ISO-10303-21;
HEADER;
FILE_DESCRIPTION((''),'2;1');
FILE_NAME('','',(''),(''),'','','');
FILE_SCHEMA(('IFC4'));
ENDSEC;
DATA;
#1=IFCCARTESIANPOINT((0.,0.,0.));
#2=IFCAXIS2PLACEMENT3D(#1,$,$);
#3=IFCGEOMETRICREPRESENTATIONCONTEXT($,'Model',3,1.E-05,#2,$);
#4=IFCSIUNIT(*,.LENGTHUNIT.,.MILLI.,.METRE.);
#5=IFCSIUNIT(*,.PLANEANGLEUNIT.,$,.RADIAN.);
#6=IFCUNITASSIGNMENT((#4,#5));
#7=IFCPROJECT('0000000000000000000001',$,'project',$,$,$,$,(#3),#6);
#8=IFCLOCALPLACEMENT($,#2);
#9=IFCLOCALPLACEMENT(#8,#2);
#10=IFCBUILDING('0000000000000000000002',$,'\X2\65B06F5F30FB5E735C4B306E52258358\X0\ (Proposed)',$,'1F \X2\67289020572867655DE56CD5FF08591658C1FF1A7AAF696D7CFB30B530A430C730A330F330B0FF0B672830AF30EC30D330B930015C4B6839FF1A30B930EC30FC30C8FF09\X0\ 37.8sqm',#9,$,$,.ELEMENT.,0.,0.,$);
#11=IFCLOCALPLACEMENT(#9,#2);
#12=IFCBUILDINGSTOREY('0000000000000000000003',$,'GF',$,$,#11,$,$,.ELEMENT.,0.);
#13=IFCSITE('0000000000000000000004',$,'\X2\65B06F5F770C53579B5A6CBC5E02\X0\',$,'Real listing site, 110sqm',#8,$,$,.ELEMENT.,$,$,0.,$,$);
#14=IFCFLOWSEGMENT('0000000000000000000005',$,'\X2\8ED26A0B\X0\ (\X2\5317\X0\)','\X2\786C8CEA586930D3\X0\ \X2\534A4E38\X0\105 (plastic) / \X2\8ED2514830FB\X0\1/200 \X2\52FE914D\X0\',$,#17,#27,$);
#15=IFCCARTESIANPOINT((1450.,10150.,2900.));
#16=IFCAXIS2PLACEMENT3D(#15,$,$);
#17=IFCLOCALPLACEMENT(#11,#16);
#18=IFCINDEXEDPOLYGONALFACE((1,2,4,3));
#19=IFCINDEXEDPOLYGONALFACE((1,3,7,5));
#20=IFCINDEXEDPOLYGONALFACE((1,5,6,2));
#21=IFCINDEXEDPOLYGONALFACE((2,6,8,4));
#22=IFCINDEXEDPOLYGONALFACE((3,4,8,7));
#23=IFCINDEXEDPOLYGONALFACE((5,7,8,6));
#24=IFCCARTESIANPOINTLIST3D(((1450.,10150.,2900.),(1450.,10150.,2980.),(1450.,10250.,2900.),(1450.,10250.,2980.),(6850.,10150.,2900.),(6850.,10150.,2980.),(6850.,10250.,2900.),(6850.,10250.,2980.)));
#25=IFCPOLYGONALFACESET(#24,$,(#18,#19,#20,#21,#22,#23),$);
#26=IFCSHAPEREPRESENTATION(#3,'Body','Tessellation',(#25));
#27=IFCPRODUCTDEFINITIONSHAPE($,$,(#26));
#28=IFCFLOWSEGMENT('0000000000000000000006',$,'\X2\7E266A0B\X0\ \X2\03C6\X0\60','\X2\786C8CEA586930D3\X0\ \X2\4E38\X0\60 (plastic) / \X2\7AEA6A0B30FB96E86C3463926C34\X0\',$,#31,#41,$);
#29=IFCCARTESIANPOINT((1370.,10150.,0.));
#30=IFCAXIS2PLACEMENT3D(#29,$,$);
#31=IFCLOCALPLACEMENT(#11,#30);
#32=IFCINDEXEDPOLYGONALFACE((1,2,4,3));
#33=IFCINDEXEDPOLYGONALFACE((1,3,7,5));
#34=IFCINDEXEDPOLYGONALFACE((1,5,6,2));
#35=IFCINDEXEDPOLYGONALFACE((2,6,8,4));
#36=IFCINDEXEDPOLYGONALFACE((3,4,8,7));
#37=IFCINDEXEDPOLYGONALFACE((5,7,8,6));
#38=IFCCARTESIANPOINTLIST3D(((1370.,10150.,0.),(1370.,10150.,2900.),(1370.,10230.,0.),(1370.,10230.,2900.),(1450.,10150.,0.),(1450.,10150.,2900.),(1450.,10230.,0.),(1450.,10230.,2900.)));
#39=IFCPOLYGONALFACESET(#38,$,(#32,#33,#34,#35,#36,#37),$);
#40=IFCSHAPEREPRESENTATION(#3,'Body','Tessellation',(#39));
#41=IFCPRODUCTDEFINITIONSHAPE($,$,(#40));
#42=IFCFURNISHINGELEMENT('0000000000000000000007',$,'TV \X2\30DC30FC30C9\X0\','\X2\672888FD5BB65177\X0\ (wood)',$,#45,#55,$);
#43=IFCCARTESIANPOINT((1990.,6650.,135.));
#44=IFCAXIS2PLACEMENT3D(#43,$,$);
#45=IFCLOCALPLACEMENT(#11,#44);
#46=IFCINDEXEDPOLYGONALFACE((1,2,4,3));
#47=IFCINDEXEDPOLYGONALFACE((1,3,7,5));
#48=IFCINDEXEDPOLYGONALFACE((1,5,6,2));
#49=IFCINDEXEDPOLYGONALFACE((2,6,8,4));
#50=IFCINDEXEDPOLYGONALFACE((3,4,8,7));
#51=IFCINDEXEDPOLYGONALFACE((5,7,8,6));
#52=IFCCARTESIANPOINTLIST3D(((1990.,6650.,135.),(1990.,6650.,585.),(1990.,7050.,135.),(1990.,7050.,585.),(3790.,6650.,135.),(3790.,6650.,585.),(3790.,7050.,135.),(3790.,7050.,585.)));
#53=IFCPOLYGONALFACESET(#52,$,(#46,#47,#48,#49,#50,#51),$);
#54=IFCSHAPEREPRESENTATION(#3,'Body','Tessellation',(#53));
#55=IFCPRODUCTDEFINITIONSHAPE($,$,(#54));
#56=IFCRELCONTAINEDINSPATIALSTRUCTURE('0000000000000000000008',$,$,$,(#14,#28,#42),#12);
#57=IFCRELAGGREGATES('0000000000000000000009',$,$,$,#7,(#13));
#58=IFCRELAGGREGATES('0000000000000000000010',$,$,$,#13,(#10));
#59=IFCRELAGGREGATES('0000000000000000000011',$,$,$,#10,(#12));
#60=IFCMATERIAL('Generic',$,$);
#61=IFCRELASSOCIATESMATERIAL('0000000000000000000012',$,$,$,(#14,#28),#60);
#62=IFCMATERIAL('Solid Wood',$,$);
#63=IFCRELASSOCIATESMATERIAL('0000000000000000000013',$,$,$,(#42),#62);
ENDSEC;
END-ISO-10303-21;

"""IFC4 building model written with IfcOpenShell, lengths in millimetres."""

from ifc_helpers import new_model, si_unit, frame, frame_2d, origin, place, context, project, spatial, rectangle, extrude, material, element, save


model = new_model("IFC4")

# Units and contexts
model_context = context("Model", 3, precision=1e-05, world=origin())
ifc_project = project(units=[si_unit("LENGTHUNIT", "METRE", prefix="MILLI"), si_unit("PLANEANGLEUNIT", "RADIAN")], contexts=[model_context])

# Site, building, storey
site_placement = place(None, origin())
site = spatial("IfcSite", under=ifc_project, at=site_placement, Name="新潟県南魚沼市", ObjectType="Real listing site, 110sqm", CompositionType="ELEMENT", RefElevation=0.0)
building_placement = place(site_placement, origin())
building = spatial("IfcBuilding", under=site, at=building_placement, Name="新潟・平屋の別荘 (Proposed)", ObjectType="1F 木造在来工法（外壁：窯業系サイディング＋木クレビス、屋根：スレート） 37.8sqm", CompositionType="ELEMENT", ElevationOfRefHeight=0.0, ElevationOfTerrain=0.0)
storey_placement = place(building_placement, origin())
storey = spatial("IfcBuildingStorey", under=building, at=storey_placement, Name="GF", CompositionType="ELEMENT", Elevation=0.0)

# Shared definitions
ifc_material_1 = material(Name="Solid Wood")

# Shared definitions
ifc_material_2 = material(Name="Generic")

# Flow segments
flow_segment_1_placement = place(storey_placement, frame((1450.0, 10150.0, 2900.0)))
element("IfcFlowSegment", 1, at=flow_segment_1_placement, inside=storey, material=ifc_material_2, Name="軒樋 (北)", Description="硬質塩ビ 半丸105 (plastic) / 軒先・1/200 勾配", context=model_context, shape_type="SweptSolid", body=[
    extrude(rectangle(XDim=5400.0, YDim=100.0, at=frame_2d((2700.0, 50.0))), frame((1450.0, 10150.0, 2900.0)), (0.0, 0.0, 1.0), 80.0),
])
flow_segment_2_placement = place(storey_placement, frame((1370.0, 10150.0, 0.0)))
element("IfcFlowSegment", 2, at=flow_segment_2_placement, inside=storey, material=ifc_material_2, Name="縦樋 φ60", Description="硬質塩ビ 丸60 (plastic) / 竪樋・雨水排水", context=model_context, shape_type="SweptSolid", body=[
    extrude(rectangle(XDim=80.0, YDim=80.0, at=frame_2d((40.0, 40.0))), frame((1370.0, 10150.0, 0.0)), (0.0, 0.0, 1.0), 2900.0),
])

# Furnishing element
furnishing_placement = place(storey_placement, frame((1990.0, 6650.0, 135.0)))
element("IfcFurnishingElement", 3, at=furnishing_placement, inside=storey, material=ifc_material_1, Name="TV ボード", Description="木製家具 (wood)", context=model_context, shape_type="SweptSolid", body=[
    extrude(rectangle(XDim=1800.0, YDim=400.0, at=frame_2d((900.0, 200.0))), frame((1990.0, 6650.0, 135.0)), (0.0, 0.0, 1.0), 450.0),
])

save(model, "model.ifc")
